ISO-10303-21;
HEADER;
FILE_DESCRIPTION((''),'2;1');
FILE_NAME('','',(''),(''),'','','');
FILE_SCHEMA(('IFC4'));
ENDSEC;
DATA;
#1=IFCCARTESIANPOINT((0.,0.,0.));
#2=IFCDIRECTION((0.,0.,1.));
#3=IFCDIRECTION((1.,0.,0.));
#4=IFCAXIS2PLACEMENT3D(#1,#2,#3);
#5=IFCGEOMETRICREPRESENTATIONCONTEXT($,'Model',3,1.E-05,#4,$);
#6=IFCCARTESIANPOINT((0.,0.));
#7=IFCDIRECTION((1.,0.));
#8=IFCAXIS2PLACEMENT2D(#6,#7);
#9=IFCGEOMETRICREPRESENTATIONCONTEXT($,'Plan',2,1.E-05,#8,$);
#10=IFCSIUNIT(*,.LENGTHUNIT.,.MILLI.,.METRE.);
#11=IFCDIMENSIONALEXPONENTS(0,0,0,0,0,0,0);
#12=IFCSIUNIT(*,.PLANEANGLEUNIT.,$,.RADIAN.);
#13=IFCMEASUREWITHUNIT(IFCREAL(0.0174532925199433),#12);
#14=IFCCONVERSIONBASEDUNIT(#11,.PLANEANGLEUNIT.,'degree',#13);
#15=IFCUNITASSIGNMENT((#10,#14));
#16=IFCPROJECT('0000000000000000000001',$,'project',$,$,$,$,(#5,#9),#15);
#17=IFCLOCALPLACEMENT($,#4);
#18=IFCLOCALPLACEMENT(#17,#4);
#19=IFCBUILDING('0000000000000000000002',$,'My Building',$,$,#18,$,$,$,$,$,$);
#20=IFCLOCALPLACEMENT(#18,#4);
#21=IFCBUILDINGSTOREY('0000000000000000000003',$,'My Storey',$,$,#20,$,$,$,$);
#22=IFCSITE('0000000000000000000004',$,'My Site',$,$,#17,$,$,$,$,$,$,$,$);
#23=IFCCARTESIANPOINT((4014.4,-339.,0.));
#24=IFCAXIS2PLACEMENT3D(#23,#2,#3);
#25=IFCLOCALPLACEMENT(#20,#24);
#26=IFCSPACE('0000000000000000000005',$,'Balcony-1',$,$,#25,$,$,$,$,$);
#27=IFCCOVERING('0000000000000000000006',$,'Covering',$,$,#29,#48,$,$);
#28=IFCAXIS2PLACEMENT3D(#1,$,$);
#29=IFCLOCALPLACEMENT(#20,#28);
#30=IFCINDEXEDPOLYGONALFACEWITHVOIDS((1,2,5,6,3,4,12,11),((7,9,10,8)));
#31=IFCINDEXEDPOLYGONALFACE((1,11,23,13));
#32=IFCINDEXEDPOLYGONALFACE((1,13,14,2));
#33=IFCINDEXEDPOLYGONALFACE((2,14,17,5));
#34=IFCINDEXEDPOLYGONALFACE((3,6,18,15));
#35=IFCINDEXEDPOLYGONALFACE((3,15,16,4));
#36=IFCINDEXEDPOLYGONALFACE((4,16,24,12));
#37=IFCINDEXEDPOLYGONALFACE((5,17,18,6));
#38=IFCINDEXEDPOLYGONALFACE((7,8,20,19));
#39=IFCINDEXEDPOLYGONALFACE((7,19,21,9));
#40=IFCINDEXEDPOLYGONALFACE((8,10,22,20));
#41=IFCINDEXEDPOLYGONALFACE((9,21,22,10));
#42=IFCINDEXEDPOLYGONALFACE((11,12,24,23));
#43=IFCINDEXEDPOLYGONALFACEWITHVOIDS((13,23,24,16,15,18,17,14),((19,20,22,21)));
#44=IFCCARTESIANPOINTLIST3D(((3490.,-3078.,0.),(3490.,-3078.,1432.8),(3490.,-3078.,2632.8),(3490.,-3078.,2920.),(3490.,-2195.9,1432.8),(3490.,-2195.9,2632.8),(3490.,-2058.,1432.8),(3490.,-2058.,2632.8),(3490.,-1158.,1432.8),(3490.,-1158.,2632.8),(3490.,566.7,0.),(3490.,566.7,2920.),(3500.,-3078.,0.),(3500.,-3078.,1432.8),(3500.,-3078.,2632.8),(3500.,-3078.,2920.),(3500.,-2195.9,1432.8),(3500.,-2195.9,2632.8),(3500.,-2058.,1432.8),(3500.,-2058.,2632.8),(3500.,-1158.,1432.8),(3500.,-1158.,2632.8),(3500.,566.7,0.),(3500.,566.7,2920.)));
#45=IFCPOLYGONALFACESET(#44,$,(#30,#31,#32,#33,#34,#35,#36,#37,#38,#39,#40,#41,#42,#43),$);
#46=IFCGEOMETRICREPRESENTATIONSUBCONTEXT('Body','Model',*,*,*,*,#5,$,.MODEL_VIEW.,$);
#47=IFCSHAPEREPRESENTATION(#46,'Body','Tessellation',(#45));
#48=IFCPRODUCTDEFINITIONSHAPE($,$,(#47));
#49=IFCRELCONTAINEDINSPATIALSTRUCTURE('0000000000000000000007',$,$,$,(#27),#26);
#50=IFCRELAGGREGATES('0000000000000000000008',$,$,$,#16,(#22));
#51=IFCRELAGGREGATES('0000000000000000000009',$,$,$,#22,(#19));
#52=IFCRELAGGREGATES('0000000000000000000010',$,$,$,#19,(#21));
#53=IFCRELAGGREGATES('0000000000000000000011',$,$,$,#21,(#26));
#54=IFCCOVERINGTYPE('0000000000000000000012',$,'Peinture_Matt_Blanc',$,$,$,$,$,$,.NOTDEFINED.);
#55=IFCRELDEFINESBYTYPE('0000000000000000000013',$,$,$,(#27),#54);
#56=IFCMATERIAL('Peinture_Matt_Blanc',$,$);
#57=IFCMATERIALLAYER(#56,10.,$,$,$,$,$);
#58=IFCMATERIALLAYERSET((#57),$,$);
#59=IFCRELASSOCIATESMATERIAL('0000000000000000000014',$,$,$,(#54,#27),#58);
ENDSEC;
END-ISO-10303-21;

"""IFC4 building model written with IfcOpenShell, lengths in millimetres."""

from ifc_helpers import new_model, entity, si_unit, converted_unit, frame, origin_with_axes, origin_2d_with_axis, place, context, subcontext, project, spatial, line, indexed_curve, outline, extrude, clip, halfspace, source, transform, mapped, material, layer, layer_set, layer_usage, type_object, element, save


model = new_model("IFC4")

# Units and contexts
model_context = context("Model", 3, precision=1e-05, world=origin_with_axes())
plan_context = context("Plan", 2, precision=1e-05, world=origin_2d_with_axis())
body_context_1 = subcontext(model_context, "Body", "Model", "MODEL_VIEW")
ifc_project = project(units=[si_unit("LENGTHUNIT", "METRE", prefix="MILLI"), converted_unit("PLANEANGLEUNIT", "degree", entity("IfcReal", 0.0174532925199433), si_unit("PLANEANGLEUNIT", "RADIAN"), dimensions=[0, 0, 0, 0, 0, 0, 0])], contexts=[model_context, plan_context])

# Site, building, storey
site_placement = place(None, origin_with_axes())
site = spatial("IfcSite", under=ifc_project, at=site_placement, Name="My Site")
building_placement = place(site_placement, origin_with_axes())
building = spatial("IfcBuilding", under=site, at=building_placement, Name="My Building")
storey_placement = place(building_placement, origin_with_axes())
storey = spatial("IfcBuildingStorey", under=building, at=storey_placement, Name="My Storey")

# Shared definitions
ifc_material_1 = material(Name="Peinture_Matt_Blanc")
ifc_layer_1 = layer(ifc_material_1, 10.0)
ifc_layer_set_1 = layer_set([ifc_layer_1])
covering_type_1 = type_object("IfcCoveringType", Name="Peinture_Matt_Blanc", PredefinedType="NOTDEFINED", material=ifc_layer_set_1)

# Shared definitions
space_1_placement = place(storey_placement, frame((4014.4, -339.0, 0.0), z_axis=(0.0, 0.0, 1.0), x_axis=(1.0, 0.0, 0.0)))
space_1 = spatial("IfcSpace", under=storey, at=space_1_placement, Name="Balcony-1")

# Covering, openings
ifc_layer_usage_1 = layer_usage(ifc_layer_set_1, "AXIS2", "POSITIVE", 0.0)
covering_1_placement = place(space_1_placement, frame((-524.4, 905.7, 0.0), z_axis=(0.0, 0.0, 1.0), x_axis=(-0.000003, -1.0, 0.0)))
covering_1 = element("IfcCovering", 1, at=covering_1_placement, inside=space_1, type_object=covering_type_1, material=ifc_layer_usage_1, Name="Covering", context=body_context_1, shape_type="Clipping", body=[
    clip(extrude(outline(indexed_curve([(0.0, 0.0), (0.0, 10.0), (3644.7, 10.0), (3644.7, 0.0), (0.0, 0.0)], self_intersect=False)), origin_with_axes(), (0.0, 0.0, 1.0), 2920.0), halfspace(frame((0.0, 0.0, 2920.0), z_axis=(0.0, 0.0, 1.0), x_axis=(-1.0, 0.0, 0.0)), False)),
])
shared_shape_1 = source(origin_with_axes(), body_context_1, "Body", "SweptSolid", [
    extrude(outline(indexed_curve([(0.0, 0.0), (900.0, 0.0), (900.0, 1200.0), (0.0, 1200.0)], segments=[line(1, 2, 3, 4, 1)])), frame((0.0, -600.0, 0.0), z_axis=(0.0, -1.0, 0.0), x_axis=(1.0, 0.0, 0.0)), (0.0, 0.0, -1.0), 1200.0),
])
opening_1_placement = place(covering_1_placement, frame((2762.6, -485.0, 1432.8), z_axis=(0.0, 0.0, 1.0), x_axis=(1.0, 0.000002, 0.0)))
element("IfcOpeningElement", 2, at=opening_1_placement, cuts=covering_1, PredefinedType="OPENING", context=body_context_1, shape_type="MappedRepresentation", body=[
    mapped(shared_shape_1, transform((0.0, 0.0, 0.0), x_axis=(1.0, 0.0, 0.0), y_axis=(0.0, 1.0, 0.0), z_axis=(0.0, 0.0, 1.0), scale=1.0)),
])
shared_shape_2 = source(origin_with_axes(), body_context_1, "Body", "SweptSolid", [
    extrude(outline(indexed_curve([(0.0, 0.0), (900.0, 0.0), (900.0, 1200.0), (0.0, 1200.0)], segments=[line(1, 2, 3, 4, 1)])), frame((0.0, -600.0, 0.0), z_axis=(0.0, -1.0, 0.0), x_axis=(1.0, 0.0, 0.0)), (0.0, 0.0, -1.0), 1200.0),
])
opening_2_placement = place(covering_1_placement, frame((1724.7, -485.0, 1432.8), z_axis=(0.0, 0.0, 1.0), x_axis=(1.0, 0.000002, 0.0)))
element("IfcOpeningElement", 3, at=opening_2_placement, cuts=covering_1, PredefinedType="OPENING", context=body_context_1, shape_type="MappedRepresentation", body=[
    mapped(shared_shape_2, transform((0.0, 0.0, 0.0), x_axis=(1.0, 0.0, 0.0), y_axis=(0.0, 1.0, 0.0), z_axis=(0.0, 0.0, 1.0), scale=1.0)),
])

save(model, "model.ifc")
